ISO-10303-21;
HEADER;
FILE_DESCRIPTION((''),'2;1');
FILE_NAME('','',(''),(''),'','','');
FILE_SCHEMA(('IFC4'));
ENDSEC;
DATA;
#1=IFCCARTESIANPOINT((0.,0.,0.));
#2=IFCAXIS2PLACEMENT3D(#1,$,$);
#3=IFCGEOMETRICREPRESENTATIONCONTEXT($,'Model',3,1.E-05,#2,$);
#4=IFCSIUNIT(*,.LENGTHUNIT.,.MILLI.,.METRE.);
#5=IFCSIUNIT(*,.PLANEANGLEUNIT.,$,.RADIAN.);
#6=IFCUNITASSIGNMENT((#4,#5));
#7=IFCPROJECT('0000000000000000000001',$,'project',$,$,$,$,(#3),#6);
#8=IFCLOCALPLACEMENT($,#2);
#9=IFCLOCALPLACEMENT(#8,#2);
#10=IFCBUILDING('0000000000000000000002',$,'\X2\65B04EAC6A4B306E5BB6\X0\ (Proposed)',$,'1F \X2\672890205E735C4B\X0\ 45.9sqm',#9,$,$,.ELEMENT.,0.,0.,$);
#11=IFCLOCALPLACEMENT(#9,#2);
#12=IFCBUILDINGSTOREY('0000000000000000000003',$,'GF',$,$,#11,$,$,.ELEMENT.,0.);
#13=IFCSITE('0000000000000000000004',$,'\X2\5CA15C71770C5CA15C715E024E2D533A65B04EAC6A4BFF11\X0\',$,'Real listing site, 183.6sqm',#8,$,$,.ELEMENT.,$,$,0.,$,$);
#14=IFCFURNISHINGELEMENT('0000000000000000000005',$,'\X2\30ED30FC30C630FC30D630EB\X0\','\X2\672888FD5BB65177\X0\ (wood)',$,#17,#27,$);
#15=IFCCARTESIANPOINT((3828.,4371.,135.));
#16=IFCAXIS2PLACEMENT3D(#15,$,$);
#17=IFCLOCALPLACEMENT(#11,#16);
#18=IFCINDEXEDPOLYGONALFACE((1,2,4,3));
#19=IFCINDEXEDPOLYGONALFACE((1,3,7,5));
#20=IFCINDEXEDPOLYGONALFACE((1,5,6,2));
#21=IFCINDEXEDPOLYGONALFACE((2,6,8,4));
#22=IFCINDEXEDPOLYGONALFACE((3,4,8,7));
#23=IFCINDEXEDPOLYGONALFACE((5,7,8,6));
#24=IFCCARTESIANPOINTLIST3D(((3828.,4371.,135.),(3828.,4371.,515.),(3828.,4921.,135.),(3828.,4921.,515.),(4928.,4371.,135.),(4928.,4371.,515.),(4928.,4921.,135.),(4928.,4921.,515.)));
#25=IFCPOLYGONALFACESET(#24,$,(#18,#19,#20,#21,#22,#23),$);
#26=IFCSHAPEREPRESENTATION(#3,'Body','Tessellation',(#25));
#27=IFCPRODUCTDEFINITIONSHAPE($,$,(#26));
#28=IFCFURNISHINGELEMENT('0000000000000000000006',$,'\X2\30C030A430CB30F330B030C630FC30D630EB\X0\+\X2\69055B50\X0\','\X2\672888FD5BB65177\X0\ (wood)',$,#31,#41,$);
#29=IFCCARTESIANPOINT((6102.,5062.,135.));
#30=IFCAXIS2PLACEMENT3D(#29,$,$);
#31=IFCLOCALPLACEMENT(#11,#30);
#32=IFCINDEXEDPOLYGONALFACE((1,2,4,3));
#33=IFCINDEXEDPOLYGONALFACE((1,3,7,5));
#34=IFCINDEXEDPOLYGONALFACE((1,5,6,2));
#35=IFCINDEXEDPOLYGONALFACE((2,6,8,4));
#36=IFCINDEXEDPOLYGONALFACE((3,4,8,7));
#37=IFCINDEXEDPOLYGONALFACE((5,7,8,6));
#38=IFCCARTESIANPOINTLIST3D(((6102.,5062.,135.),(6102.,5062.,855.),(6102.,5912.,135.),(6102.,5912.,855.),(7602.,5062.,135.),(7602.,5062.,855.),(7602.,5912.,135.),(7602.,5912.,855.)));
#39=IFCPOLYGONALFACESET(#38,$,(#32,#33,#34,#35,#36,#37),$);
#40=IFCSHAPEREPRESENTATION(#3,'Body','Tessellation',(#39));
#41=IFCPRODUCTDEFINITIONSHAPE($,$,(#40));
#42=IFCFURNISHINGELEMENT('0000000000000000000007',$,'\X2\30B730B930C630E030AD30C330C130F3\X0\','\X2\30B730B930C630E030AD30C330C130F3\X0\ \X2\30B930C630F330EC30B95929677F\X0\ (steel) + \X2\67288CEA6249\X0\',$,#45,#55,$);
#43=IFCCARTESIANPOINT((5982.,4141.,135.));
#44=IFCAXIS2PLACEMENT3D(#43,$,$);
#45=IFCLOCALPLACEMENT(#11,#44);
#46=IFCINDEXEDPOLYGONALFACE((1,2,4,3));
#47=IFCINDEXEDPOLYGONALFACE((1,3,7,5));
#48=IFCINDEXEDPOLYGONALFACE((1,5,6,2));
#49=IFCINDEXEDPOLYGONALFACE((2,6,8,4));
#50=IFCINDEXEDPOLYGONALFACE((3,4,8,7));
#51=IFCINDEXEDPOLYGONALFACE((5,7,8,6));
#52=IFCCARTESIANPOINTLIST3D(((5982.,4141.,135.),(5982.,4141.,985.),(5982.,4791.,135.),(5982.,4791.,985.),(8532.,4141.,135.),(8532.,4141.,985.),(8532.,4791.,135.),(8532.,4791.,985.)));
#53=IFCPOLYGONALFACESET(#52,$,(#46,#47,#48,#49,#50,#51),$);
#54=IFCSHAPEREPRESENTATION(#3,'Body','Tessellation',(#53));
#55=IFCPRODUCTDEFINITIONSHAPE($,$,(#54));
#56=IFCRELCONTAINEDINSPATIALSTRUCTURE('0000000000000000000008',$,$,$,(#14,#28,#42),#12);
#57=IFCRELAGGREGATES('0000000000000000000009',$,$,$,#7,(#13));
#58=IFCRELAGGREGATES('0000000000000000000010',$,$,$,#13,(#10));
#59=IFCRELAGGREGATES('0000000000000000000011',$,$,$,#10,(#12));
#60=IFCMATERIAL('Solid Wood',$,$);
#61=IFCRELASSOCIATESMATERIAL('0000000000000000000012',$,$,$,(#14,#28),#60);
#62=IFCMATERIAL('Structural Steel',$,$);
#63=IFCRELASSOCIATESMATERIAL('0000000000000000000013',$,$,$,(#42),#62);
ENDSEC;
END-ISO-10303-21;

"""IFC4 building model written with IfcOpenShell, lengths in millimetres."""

from ifc_helpers import new_model, si_unit, frame, frame_2d, origin, place, context, project, spatial, rectangle, extrude, material, element, save


model = new_model("IFC4")

# Units and contexts
model_context = context("Model", 3, precision=1e-05, world=origin())
ifc_project = project(units=[si_unit("LENGTHUNIT", "METRE", prefix="MILLI"), si_unit("PLANEANGLEUNIT", "RADIAN")], contexts=[model_context])

# Site, building, storey
site_placement = place(None, origin())
site = spatial("IfcSite", under=ifc_project, at=site_placement, Name="岡山県岡山市中区新京橋１", ObjectType="Real listing site, 183.6sqm", CompositionType="ELEMENT", RefElevation=0.0)
building_placement = place(site_placement, origin())
building = spatial("IfcBuilding", under=site, at=building_placement, Name="新京橋の家 (Proposed)", ObjectType="1F 木造平屋 45.9sqm", CompositionType="ELEMENT", ElevationOfRefHeight=0.0, ElevationOfTerrain=0.0)
storey_placement = place(building_placement, origin())
storey = spatial("IfcBuildingStorey", under=building, at=storey_placement, Name="GF", CompositionType="ELEMENT", Elevation=0.0)

# Shared definitions
ifc_material_1 = material(Name="Solid Wood")

# Shared definitions
ifc_material_2 = material(Name="Structural Steel")

# Furnishing elements
furnishing_1_placement = place(storey_placement, frame((3828.0, 4371.0, 135.0)))
element("IfcFurnishingElement", 1, at=furnishing_1_placement, inside=storey, material=ifc_material_1, Name="ローテーブル", Description="木製家具 (wood)", context=model_context, shape_type="SweptSolid", body=[
    extrude(rectangle(XDim=1100.0, YDim=550.0, at=frame_2d((550.0, 275.0))), frame((3828.0, 4371.0, 135.0)), (0.0, 0.0, 1.0), 380.0),
])
furnishing_2_placement = place(storey_placement, frame((6102.0, 5062.0, 135.0)))
element("IfcFurnishingElement", 2, at=furnishing_2_placement, inside=storey, material=ifc_material_1, Name="ダイニングテーブル+椅子", Description="木製家具 (wood)", context=model_context, shape_type="SweptSolid", body=[
    extrude(rectangle(XDim=1500.0, YDim=850.0, at=frame_2d((750.0, 425.0))), frame((6102.0, 5062.0, 135.0)), (0.0, 0.0, 1.0), 720.0),
])
furnishing_3_placement = place(storey_placement, frame((5982.0, 4141.0, 135.0)))
element("IfcFurnishingElement", 3, at=furnishing_3_placement, inside=storey, material=ifc_material_2, Name="システムキッチン", Description="システムキッチン ステンレス天板 (steel) + 木質扉", context=model_context, shape_type="SweptSolid", body=[
    extrude(rectangle(XDim=2550.0, YDim=650.0, at=frame_2d((1275.0, 325.0))), frame((5982.0, 4141.0, 135.0)), (0.0, 0.0, 1.0), 850.0),
])

save(model, "model.ifc")
